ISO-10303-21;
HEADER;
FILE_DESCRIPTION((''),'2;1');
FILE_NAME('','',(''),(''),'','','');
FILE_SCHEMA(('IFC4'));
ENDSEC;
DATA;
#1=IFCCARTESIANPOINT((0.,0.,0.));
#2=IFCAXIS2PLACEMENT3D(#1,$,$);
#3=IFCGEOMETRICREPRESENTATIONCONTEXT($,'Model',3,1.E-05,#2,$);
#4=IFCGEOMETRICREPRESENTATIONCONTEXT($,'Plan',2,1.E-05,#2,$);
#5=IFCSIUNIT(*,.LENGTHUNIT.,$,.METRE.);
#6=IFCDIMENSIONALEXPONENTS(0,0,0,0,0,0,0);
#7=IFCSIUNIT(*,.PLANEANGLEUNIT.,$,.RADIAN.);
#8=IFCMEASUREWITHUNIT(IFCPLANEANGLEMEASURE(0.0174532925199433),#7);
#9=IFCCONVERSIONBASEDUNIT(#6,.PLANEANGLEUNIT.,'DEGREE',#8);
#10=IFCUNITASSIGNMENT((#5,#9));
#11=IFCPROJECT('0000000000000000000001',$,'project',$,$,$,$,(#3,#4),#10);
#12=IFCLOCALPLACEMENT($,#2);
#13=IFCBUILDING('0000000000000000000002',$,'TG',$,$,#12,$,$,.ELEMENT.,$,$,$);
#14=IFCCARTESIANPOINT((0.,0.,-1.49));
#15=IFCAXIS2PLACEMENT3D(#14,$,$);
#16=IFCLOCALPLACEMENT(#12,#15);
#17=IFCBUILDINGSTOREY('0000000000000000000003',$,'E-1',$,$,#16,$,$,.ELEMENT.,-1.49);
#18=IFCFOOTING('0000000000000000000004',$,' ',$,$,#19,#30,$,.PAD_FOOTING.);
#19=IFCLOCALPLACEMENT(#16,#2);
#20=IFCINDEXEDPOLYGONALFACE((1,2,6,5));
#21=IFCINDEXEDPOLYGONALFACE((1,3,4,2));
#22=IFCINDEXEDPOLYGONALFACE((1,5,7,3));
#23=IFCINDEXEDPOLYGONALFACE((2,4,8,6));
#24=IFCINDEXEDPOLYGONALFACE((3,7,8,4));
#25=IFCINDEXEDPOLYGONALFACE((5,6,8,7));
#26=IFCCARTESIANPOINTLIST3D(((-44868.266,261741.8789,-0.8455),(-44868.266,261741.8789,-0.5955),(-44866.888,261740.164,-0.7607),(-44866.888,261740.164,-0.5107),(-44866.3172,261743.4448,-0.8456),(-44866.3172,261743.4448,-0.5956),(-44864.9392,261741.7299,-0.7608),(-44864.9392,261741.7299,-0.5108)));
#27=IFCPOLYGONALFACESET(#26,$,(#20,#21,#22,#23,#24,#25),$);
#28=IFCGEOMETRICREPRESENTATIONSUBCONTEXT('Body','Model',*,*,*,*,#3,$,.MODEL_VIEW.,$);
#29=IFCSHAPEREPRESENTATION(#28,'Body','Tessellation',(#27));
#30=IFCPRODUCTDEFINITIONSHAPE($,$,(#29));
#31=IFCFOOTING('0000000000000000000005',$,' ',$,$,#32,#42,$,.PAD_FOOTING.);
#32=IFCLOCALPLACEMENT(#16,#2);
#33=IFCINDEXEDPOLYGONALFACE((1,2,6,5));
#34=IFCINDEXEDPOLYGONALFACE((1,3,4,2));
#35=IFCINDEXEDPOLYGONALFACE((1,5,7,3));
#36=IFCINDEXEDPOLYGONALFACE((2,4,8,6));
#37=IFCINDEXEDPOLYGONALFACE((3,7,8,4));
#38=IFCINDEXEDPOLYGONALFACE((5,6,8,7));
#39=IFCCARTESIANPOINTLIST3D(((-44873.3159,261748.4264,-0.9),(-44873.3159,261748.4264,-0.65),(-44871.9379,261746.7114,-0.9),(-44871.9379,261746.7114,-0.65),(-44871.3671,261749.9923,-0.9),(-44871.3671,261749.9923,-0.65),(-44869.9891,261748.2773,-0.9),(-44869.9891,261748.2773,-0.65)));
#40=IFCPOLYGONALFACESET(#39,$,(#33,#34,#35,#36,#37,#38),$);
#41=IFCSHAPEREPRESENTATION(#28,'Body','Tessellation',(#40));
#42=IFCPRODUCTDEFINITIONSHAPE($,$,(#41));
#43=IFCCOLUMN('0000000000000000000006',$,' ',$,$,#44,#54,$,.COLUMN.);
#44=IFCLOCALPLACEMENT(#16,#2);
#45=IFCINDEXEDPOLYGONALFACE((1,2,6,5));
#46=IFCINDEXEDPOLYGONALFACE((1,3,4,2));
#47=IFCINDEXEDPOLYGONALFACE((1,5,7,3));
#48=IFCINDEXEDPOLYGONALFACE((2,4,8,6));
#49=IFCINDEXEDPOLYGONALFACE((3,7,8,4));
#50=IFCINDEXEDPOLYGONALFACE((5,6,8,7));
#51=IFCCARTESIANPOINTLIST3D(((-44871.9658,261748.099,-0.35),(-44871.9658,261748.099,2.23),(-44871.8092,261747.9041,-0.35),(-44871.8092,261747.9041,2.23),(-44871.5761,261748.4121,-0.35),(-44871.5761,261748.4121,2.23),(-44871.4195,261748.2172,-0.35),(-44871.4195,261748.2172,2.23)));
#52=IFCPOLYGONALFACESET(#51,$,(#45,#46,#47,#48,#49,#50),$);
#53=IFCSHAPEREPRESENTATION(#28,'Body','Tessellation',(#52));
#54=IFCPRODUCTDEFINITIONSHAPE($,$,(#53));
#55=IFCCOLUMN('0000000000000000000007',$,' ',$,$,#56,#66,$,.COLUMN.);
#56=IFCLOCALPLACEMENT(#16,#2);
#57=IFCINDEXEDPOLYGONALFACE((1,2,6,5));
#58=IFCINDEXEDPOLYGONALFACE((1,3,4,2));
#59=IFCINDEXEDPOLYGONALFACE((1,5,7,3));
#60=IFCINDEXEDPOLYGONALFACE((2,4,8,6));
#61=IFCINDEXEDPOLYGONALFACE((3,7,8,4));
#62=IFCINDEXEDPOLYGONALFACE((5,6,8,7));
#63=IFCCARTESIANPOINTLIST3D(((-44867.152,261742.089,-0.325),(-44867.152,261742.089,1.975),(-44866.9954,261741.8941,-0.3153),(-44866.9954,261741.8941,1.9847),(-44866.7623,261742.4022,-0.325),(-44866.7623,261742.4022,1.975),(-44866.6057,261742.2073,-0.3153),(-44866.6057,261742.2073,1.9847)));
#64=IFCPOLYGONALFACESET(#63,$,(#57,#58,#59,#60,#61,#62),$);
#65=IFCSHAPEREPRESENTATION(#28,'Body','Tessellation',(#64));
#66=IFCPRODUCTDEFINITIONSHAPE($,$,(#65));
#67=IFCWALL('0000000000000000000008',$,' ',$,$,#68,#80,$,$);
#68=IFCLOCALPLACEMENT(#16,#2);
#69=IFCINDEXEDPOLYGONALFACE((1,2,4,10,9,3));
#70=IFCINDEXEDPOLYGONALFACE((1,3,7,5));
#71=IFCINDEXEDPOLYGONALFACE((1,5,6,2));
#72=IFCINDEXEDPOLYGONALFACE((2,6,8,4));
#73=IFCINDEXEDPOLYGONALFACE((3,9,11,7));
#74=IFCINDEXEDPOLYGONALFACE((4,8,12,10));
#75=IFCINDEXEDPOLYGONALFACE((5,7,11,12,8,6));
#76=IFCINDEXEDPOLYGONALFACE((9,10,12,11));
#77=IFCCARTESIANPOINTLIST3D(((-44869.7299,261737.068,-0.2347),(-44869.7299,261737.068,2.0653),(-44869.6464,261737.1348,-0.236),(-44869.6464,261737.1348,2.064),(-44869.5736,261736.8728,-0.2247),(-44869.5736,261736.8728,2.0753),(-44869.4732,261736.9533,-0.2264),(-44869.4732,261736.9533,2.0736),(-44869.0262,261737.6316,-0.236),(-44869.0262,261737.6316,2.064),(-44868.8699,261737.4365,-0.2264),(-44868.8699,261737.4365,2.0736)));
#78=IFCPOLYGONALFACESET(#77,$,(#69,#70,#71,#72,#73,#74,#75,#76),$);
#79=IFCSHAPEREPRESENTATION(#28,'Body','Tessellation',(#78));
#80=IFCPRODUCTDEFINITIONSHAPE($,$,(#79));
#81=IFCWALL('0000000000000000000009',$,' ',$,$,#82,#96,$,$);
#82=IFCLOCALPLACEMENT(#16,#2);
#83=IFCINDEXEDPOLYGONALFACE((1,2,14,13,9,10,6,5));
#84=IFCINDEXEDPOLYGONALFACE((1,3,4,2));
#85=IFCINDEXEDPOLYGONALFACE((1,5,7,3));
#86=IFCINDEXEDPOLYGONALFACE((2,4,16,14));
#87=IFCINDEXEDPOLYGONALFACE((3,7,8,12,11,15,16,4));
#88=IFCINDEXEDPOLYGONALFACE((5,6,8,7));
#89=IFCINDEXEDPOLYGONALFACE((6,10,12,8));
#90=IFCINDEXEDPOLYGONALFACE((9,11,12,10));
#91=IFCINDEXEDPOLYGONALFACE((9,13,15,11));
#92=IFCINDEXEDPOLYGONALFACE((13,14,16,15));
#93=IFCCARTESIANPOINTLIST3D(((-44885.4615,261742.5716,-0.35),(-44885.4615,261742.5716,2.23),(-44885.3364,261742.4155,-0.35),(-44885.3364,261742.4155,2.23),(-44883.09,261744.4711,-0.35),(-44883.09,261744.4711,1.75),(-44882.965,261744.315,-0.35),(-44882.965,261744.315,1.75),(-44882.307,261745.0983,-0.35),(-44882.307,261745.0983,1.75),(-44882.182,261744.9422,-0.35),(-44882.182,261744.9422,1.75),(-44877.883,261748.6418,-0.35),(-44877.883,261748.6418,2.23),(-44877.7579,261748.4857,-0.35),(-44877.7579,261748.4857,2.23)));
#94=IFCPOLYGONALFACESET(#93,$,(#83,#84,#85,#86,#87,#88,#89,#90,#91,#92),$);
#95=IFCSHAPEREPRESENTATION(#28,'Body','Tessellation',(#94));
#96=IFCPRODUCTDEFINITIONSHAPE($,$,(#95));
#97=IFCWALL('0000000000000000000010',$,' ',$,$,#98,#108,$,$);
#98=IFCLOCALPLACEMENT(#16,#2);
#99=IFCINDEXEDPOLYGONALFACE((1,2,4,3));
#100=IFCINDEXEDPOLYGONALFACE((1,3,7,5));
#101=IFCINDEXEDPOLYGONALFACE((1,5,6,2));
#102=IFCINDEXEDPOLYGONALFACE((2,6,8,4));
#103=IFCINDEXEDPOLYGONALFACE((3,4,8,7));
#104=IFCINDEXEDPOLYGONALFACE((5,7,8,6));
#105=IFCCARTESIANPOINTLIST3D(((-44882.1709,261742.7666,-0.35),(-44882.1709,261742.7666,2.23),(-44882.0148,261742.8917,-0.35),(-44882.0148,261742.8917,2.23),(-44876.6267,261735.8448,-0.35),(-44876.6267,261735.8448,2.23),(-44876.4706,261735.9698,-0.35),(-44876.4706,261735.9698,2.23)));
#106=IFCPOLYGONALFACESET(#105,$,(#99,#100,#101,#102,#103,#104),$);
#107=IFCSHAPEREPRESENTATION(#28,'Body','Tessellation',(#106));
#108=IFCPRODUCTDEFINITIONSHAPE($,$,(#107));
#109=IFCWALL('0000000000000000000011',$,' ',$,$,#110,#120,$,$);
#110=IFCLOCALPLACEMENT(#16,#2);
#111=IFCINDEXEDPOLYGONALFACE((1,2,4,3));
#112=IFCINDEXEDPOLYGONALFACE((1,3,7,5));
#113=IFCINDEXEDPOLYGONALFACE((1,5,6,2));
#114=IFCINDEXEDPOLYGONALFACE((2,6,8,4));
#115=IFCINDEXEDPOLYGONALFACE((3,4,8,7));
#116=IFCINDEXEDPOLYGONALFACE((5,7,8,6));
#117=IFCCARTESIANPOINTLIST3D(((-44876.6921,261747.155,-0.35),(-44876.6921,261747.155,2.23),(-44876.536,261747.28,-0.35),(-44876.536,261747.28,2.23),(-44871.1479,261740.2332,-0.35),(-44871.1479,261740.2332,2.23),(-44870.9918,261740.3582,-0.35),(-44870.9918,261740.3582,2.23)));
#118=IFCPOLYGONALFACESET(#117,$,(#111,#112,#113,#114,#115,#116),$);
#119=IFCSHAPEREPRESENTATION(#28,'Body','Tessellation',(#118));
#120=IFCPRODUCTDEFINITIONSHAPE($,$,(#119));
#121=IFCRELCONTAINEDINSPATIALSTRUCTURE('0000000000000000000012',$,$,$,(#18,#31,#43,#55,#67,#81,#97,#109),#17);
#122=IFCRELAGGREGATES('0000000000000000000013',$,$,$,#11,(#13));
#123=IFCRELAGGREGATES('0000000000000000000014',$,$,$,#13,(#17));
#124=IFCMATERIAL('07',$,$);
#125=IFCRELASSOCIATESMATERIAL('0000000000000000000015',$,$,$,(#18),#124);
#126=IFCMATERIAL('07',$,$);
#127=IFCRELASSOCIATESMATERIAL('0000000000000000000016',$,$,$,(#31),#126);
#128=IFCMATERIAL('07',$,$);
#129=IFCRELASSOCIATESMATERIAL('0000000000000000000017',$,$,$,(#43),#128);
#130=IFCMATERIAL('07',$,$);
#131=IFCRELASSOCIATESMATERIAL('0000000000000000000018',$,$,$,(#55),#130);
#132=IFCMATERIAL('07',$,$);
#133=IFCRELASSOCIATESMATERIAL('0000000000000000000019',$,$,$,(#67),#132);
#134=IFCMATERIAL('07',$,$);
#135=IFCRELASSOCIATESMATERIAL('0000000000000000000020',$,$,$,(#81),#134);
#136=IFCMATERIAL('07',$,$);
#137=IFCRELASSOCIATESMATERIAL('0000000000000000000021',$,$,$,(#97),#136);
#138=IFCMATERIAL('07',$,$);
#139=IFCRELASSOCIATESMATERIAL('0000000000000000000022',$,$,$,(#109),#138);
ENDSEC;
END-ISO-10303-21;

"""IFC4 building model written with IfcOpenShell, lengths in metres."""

from ifc_helpers import new_model, entity, si_unit, converted_unit, frame, frame_2d, origin, origin_with_axes, place, context, subcontext, project, spatial, polyline, rectangle, outline, extrude, clip, halfspace, bounded_halfspace, material, element, save


model = new_model("IFC4")

# Units and contexts
model_context = context("Model", 3, precision=1e-05, world=origin())
plan_context = context("Plan", 2, precision=1e-05, world=origin())
body_context = subcontext(model_context, "Body", "Model", "MODEL_VIEW")
ifc_project = project(units=[si_unit("LENGTHUNIT", "METRE"), converted_unit("PLANEANGLEUNIT", "DEGREE", entity("IfcPlaneAngleMeasure", 0.0174532925199433), si_unit("PLANEANGLEUNIT", "RADIAN"), dimensions=[0, 0, 0, 0, 0, 0, 0])], contexts=[model_context, plan_context])

# Building, storey
building_placement = place(None, origin())
building = spatial("IfcBuilding", under=ifc_project, at=building_placement, Name="TG", CompositionType="ELEMENT")
storey_placement = place(building_placement, frame((0.0, 0.0, -1.49)))
storey = spatial("IfcBuildingStorey", under=building, at=storey_placement, Name="E-1", CompositionType="ELEMENT", Elevation=-1.49)

# Footings
ifc_material_1 = material(Name="07")
footing_1_placement = place(storey_placement, frame((-44868.266, 261740.164, -0.8456)))
element("IfcFooting", 1, at=footing_1_placement, inside=storey, material=ifc_material_1, Name=" ", PredefinedType="PAD_FOOTING", context=body_context, shape_type="Clipping", body=[
    clip(clip(extrude(rectangle(XDim=2.5, YDim=2.2, at=frame_2d((0.2854, 1.6404), x_axis=(0.779531, 0.626364))), frame((1.378, 0.0, 0.0), z_axis=(0.0, 0.0, 1.0), x_axis=(1.0, 0.0, 0.0)), (0.0, 0.0, 1.0), 0.3349), halfspace(frame((1.6634, 1.6404, 0.0425), z_axis=(-0.024077, 0.03006, 0.999258), x_axis=(0.625899, -0.778953, 0.038513)), True)), halfspace(frame((1.6634, 1.6404, 0.2925), z_axis=(0.024077, -0.03006, -0.999258), x_axis=(0.779531, 0.626364, -0.00006)), True)),
])
ifc_material_2 = material(Name="07")
footing_2_placement = place(storey_placement, frame((-44873.3159, 261746.7114, -0.9)))
element("IfcFooting", 2, at=footing_2_placement, inside=storey, material=ifc_material_2, Name=" ", PredefinedType="PAD_FOOTING", context=body_context, shape_type="SweptSolid", body=[
    extrude(rectangle(XDim=2.5, YDim=2.2, at=frame_2d((0.2854, 1.6404), x_axis=(0.779531, 0.626364))), frame((1.378, 0.0, 0.0), z_axis=(0.0, 0.0, 1.0), x_axis=(1.0, 0.0, 0.0)), (0.0, 0.0, 1.0), 0.25),
])

# Columns
ifc_material_3 = material(Name="07")
column_1_placement = place(storey_placement, frame((-44871.5761, 261748.4121, -0.35)))
element("IfcColumn", 3, at=column_1_placement, inside=storey, material=ifc_material_3, Name=" ", PredefinedType="COLUMN", context=body_context, shape_type="SweptSolid", body=[
    extrude(rectangle(XDim=0.5, YDim=0.25, at=frame_2d((-0.1166, -0.254), x_axis=(-0.779531, -0.626364))), origin_with_axes(), (0.0, 0.0, 1.0), 2.58),
])
ifc_material_4 = material(Name="07")
column_2_placement = place(storey_placement, frame((-44866.7623, 261742.4022, -0.325)))
element("IfcColumn", 4, at=column_2_placement, inside=storey, material=ifc_material_4, Name=" ", PredefinedType="COLUMN", context=body_context, shape_type="Clipping", body=[
    clip(clip(extrude(rectangle(XDim=0.5, YDim=0.25, at=frame_2d((-0.1166, -0.254), x_axis=(-0.779531, -0.626364))), origin_with_axes(), (0.0, 0.0, 1.0), 2.3097), halfspace(frame((-0.1166, -0.254, 0.0048), z_axis=(-0.024077, 0.03006, 0.999258), x_axis=(-0.625899, 0.778953, -0.038513)), True)), halfspace(frame((-0.1166, -0.254, 2.3048), z_axis=(0.024077, -0.03006, -0.999258), x_axis=(-0.779531, -0.626364, 0.00006)), True)),
])

# Wall
ifc_material_5 = material(Name="07")
wall_1_placement = place(storey_placement, frame((-44869.0262, 261737.6316, -0.236), z_axis=(0.0, 0.0, 1.0), x_axis=(-0.780498, -0.625159, 0.0)))
element("IfcWall", 5, at=wall_1_placement, inside=storey, material=ifc_material_5, Name=" ", context=body_context, shape_type="Clipping", body=[
    clip(clip(clip(clip(extrude(outline(polyline([(-1.0236, -0.1523), (-0.122, -0.1523), (-0.122, 0.0977), (-1.0236, 0.0977), (-1.0236, -0.1523)])), frame((1.0236, 0.1523, 0.0), z_axis=(0.0, 0.0, 1.0), x_axis=(1.0, 0.0, 0.0)), (0.0, 0.0, 1.0), 2.3113), bounded_halfspace(frame((0.8427, 0.125, 0.0056), z_axis=(-0.012849, -0.039625, 0.999132), x_axis=(0.0, 0.999214, 0.039628)), True, origin_with_axes(), polyline([(0.9016, 0.0), (0.9016, 0.25), (0.7729, 0.25), (0.7947, 0.0), (0.9016, 0.0)]))), bounded_halfspace(frame((0.3919, 0.125, 0.0048), z_axis=(0.0, -0.038513, 0.999258), x_axis=(-0.000029, -0.999258, -0.038513)), True, origin_with_axes(), polyline([(0.0, 0.25), (0.0, 0.0), (0.7947, 0.0), (0.7729, 0.25), (0.0, 0.25)]))), bounded_halfspace(frame((0.8427, 0.125, 2.3056), z_axis=(0.012849, 0.039625, -0.999132), x_axis=(-0.999917, 0.0, -0.012859)), True, origin_with_axes(), polyline([(0.9016, 0.25), (0.7729, 0.25), (0.7947, 0.0), (0.9016, 0.0), (0.9016, 0.25)]))), bounded_halfspace(frame((0.3919, 0.125, 2.3048), z_axis=(0.0, 0.038513, -0.999258), x_axis=(1.0, 0.0, 0.0)), True, origin_with_axes(), polyline([(0.0, 0.0), (0.7947, 0.0), (0.7729, 0.25), (0.0, 0.25), (0.0, 0.0)]))),
])

# Wall, opening
ifc_material_6 = material(Name="07")
wall_2_placement = place(storey_placement, frame((-44877.883, 261748.6418, -0.35), z_axis=(0.0, 0.0, 1.0), x_axis=(-0.780498, -0.625159, 0.0)))
wall_2 = element("IfcWall", 6, at=wall_2_placement, inside=storey, material=ifc_material_6, Name=" ", context=body_context, shape_type="SweptSolid", body=[
    extrude(rectangle(XDim=9.7098, YDim=0.2, at=frame_2d((4.8549, 0.1), x_axis=(1.0, 0.0))), origin_with_axes(), (0.0, 0.0, 1.0), 2.58),
])
opening_placement = place(wall_2_placement, frame((5.6682, 0.0, 0.0), z_axis=(0.0, 1.0, 0.0), x_axis=(0.0, 0.0, 1.0)))
element("IfcOpeningElement", 7, at=opening_placement, cuts=wall_2, ObjectType="Opening", context=body_context, shape_type="SweptSolid", body=[
    extrude(outline(polyline([(0.0, 1.0033), (2.1, 1.0033), (2.1, 0.0), (0.0, 0.0), (0.0, 1.0033)])), origin_with_axes(), (0.0, 0.0, 1.0), 0.2),
])

# Walls
ifc_material_7 = material(Name="07")
wall_3_placement = place(storey_placement, frame((-44876.4706, 261735.9698, -0.35), z_axis=(0.0, 0.0, 1.0), x_axis=(-0.625159, 0.780498, 0.0)))
element("IfcWall", 8, at=wall_3_placement, inside=storey, material=ifc_material_7, Name=" ", context=body_context, shape_type="SweptSolid", body=[
    extrude(rectangle(XDim=8.8685, YDim=0.2, at=frame_2d((4.4342, 0.1), x_axis=(1.0, 0.0))), origin_with_axes(), (0.0, 0.0, 1.0), 2.58),
])
ifc_material_8 = material(Name="07")
wall_4_placement = place(storey_placement, frame((-44876.6921, 261747.155, -0.35), z_axis=(0.0, 0.0, 1.0), x_axis=(0.625159, -0.780498, 0.0)))
element("IfcWall", 9, at=wall_4_placement, inside=storey, material=ifc_material_8, Name=" ", context=body_context, shape_type="SweptSolid", body=[
    extrude(rectangle(XDim=8.8685, YDim=0.2, at=frame_2d((4.4342, 0.1), x_axis=(1.0, 0.0))), origin_with_axes(), (0.0, 0.0, 1.0), 2.58),
])

save(model, "model.ifc")
